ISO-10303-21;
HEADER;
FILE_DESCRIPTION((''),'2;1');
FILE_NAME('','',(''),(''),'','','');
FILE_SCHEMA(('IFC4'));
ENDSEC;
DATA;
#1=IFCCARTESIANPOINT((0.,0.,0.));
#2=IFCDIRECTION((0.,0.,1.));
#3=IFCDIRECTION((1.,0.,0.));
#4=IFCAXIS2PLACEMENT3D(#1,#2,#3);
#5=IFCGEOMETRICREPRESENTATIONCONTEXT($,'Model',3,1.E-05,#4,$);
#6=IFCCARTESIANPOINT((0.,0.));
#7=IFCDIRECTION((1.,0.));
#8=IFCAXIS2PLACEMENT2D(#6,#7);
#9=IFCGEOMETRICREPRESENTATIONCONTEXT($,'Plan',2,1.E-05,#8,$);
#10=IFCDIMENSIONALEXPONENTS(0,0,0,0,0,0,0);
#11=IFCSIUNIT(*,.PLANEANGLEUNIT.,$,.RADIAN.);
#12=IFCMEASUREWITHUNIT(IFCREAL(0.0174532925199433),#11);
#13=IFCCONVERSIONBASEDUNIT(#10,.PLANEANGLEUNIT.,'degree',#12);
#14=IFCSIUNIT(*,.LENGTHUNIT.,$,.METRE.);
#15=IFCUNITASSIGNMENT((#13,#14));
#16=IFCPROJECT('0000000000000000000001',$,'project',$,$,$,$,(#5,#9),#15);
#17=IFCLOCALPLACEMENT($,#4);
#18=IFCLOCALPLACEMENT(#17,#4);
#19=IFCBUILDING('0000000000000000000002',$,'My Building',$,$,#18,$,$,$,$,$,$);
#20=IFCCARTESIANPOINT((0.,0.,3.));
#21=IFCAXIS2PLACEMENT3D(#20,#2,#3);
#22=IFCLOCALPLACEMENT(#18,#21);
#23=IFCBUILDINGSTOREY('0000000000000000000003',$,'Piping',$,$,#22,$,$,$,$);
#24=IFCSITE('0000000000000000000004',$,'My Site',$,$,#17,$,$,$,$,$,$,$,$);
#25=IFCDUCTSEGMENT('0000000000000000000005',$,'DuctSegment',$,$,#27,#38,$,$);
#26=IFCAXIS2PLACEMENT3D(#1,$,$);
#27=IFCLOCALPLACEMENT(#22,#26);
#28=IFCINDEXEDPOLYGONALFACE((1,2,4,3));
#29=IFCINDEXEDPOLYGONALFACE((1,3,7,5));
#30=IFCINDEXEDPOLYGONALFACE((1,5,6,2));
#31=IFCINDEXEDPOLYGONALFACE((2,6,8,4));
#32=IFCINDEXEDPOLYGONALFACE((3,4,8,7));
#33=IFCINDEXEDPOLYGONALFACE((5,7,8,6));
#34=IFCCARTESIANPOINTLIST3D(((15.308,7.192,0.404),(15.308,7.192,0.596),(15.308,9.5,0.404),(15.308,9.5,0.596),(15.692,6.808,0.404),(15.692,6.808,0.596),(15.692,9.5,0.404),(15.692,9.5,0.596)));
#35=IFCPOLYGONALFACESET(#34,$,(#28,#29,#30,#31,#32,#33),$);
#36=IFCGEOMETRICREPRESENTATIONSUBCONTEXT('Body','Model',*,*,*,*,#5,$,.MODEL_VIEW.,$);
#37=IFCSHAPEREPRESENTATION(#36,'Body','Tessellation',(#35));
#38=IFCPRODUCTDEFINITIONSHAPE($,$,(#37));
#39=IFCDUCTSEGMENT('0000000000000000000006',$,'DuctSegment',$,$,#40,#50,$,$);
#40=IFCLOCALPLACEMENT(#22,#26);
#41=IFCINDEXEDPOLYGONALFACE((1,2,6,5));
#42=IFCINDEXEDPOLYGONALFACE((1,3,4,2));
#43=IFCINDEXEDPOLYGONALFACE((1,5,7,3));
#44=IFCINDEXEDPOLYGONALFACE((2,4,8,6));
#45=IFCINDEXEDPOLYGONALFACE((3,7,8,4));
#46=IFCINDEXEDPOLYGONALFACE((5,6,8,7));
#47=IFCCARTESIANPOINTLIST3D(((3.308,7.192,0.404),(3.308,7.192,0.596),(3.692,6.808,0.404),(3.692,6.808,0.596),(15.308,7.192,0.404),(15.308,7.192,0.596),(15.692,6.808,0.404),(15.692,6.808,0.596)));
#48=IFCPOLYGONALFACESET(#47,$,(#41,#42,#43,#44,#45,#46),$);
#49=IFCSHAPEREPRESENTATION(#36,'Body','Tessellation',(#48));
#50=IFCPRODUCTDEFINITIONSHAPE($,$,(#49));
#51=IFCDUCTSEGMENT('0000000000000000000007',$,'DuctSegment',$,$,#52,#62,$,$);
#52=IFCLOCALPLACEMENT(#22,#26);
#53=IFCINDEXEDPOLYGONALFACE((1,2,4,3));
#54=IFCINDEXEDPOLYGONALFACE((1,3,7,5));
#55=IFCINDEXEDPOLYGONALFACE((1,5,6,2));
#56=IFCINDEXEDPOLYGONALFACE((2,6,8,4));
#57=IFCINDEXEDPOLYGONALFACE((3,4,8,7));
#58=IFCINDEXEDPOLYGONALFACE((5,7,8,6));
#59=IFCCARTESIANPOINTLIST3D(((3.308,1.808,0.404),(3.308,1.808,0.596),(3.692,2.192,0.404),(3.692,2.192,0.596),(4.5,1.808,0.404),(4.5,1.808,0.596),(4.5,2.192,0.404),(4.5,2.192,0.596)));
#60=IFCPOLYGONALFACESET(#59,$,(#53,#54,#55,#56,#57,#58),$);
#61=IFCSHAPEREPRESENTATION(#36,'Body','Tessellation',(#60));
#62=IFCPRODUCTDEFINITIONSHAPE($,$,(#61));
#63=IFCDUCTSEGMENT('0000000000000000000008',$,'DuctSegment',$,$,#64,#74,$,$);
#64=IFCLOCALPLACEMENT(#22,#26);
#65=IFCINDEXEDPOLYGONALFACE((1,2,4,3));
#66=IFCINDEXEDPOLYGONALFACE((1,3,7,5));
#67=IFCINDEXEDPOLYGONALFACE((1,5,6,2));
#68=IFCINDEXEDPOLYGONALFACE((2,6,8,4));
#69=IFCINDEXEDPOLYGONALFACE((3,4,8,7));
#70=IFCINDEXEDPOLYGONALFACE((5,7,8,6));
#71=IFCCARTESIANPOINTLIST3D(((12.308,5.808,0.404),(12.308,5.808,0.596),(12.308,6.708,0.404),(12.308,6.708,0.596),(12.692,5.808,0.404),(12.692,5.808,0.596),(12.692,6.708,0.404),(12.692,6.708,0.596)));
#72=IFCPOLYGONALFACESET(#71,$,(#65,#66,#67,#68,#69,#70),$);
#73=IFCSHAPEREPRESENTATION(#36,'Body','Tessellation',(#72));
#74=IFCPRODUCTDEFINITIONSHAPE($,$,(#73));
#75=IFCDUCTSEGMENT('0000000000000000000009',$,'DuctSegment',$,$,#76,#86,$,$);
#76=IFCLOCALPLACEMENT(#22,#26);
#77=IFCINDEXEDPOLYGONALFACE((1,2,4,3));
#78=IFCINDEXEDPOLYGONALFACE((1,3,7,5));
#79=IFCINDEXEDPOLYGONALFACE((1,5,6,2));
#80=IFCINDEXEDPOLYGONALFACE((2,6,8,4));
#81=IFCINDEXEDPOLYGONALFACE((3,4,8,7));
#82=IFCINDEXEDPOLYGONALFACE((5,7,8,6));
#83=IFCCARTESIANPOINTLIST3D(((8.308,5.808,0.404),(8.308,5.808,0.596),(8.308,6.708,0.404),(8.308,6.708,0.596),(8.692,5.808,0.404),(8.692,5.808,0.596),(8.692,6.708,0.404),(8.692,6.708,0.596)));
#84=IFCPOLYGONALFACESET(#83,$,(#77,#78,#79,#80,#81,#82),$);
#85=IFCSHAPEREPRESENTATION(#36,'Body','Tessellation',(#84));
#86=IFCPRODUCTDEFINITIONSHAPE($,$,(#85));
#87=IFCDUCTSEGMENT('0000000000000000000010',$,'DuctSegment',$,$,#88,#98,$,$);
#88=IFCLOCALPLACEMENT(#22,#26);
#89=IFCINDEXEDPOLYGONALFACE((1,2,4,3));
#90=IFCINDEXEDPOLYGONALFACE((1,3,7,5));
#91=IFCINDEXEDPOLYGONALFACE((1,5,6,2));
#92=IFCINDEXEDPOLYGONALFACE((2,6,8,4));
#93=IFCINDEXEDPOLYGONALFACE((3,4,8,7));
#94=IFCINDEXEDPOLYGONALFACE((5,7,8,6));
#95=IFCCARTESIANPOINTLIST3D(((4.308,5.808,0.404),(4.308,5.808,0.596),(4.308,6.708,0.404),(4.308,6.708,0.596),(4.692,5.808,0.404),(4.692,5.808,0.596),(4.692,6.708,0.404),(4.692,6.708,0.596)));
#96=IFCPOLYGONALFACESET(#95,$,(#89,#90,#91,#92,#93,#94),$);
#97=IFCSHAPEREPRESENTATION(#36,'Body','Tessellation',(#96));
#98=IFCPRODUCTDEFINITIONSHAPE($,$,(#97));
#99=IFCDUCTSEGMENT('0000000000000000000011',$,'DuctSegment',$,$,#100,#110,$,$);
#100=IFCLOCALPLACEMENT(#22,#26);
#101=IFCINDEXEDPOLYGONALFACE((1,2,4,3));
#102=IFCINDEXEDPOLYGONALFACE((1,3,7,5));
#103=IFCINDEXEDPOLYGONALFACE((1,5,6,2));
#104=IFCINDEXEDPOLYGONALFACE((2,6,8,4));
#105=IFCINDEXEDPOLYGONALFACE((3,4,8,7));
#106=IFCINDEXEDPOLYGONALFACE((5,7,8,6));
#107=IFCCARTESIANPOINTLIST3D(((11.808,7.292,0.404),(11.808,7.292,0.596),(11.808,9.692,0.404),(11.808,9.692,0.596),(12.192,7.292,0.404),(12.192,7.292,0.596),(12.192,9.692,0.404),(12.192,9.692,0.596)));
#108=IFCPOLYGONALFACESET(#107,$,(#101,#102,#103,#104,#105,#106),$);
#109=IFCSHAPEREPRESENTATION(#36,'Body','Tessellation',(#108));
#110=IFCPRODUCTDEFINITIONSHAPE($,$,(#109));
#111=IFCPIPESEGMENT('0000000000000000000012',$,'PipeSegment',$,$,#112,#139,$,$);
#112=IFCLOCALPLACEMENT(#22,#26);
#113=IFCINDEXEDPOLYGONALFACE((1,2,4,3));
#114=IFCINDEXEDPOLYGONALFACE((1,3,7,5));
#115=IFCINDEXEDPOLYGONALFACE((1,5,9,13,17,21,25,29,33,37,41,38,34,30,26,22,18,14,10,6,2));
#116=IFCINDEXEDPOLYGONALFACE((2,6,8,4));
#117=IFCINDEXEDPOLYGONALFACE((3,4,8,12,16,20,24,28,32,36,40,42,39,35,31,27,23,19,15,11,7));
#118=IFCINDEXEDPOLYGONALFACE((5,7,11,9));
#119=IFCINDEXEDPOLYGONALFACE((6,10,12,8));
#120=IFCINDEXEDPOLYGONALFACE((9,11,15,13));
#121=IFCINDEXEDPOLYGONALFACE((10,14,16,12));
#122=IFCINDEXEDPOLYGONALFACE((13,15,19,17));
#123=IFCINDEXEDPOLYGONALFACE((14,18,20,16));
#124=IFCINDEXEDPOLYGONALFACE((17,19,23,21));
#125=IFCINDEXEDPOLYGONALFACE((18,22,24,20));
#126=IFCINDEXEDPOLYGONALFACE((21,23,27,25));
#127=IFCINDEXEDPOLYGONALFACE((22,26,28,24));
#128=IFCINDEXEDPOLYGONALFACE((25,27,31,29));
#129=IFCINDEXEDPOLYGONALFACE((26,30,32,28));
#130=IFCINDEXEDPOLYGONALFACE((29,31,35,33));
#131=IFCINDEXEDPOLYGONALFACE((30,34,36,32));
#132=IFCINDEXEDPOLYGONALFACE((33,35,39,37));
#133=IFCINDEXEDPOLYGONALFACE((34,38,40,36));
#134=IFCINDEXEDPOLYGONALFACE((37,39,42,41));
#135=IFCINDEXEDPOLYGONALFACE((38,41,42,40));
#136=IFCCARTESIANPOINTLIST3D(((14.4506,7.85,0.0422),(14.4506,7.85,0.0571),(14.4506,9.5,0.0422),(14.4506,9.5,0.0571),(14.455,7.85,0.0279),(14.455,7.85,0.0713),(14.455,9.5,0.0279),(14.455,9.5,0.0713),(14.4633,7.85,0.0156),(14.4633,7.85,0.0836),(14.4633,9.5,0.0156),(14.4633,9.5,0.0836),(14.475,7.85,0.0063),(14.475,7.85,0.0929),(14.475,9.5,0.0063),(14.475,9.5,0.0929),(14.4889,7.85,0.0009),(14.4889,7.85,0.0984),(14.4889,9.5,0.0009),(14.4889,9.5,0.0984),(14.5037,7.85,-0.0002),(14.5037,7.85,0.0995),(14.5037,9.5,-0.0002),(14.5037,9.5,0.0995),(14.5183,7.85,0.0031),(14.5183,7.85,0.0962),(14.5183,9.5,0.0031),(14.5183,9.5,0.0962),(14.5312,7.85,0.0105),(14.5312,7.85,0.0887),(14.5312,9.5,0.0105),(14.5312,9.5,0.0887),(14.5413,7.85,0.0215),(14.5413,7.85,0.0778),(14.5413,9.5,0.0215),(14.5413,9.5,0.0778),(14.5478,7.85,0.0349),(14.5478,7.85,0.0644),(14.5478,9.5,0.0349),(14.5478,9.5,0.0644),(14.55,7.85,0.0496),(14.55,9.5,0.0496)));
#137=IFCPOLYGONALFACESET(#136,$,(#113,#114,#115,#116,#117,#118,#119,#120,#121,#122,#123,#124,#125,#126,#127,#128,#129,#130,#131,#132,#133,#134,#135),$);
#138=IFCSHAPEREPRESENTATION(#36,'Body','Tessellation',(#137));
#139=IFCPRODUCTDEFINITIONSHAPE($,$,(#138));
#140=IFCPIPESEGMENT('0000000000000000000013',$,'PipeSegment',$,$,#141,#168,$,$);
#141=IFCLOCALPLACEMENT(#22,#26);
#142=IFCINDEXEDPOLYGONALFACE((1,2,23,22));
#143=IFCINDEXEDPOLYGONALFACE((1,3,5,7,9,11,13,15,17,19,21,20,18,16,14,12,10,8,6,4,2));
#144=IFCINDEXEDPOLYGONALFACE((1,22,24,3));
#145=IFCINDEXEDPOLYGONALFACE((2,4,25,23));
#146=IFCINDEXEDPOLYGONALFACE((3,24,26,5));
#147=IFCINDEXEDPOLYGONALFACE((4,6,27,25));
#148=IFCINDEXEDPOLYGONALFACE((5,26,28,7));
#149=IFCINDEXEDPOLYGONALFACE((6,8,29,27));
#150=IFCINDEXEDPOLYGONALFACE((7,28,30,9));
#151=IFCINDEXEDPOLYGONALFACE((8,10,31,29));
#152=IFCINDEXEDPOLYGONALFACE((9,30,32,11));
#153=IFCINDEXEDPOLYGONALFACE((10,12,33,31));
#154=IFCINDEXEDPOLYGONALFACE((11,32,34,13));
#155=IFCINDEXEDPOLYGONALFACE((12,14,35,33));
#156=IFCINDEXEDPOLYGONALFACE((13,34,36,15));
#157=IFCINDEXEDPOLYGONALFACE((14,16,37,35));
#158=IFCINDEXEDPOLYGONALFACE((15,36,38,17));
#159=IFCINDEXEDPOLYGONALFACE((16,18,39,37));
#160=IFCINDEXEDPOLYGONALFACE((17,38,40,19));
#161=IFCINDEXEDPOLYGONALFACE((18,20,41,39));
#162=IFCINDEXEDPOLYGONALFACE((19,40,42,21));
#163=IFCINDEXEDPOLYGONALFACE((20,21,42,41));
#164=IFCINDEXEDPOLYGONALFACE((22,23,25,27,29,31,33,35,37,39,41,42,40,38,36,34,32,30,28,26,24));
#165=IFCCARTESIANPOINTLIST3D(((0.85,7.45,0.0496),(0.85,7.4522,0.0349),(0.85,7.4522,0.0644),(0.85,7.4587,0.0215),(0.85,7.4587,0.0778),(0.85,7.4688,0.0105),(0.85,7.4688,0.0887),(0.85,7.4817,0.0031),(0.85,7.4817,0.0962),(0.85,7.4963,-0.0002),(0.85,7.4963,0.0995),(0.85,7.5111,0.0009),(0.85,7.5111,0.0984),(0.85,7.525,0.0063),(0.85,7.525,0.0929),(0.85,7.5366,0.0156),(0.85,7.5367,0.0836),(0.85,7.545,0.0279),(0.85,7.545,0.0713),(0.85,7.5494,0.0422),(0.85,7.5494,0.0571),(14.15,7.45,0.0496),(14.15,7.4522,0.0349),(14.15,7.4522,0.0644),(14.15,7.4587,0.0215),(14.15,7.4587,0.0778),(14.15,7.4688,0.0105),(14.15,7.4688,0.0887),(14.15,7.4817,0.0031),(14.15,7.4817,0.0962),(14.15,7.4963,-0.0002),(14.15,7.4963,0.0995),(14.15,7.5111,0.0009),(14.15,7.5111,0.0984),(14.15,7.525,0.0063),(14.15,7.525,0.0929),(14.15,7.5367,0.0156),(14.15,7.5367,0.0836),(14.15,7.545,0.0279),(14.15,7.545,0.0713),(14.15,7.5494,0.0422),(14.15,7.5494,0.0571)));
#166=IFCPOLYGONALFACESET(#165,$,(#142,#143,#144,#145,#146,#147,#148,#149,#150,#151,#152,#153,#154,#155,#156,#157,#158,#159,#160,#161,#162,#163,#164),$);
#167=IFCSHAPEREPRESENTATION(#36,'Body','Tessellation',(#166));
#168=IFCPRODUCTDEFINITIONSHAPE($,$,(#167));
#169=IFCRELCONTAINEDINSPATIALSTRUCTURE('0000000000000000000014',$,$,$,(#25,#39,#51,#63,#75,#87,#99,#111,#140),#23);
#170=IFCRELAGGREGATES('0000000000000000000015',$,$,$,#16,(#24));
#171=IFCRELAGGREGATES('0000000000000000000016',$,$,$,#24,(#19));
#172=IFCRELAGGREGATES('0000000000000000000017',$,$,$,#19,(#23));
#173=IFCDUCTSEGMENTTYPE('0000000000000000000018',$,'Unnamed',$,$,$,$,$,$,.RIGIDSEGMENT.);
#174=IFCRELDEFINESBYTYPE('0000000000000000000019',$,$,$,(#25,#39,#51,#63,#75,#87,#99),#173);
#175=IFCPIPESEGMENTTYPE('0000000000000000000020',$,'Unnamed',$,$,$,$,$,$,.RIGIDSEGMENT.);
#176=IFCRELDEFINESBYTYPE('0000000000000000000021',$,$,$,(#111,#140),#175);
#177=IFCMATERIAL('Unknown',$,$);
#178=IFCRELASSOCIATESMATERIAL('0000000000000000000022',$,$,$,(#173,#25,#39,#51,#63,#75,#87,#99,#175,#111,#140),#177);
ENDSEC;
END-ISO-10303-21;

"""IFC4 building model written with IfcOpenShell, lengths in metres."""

from ifc_helpers import new_model, entity, si_unit, converted_unit, frame, origin_with_axes, origin_2d_with_axis, place, context, subcontext, project, spatial, indexed_curve, circle, outline, extrude, clip, halfspace, material, material_profile, profile_set, profile_usage, type_object, element, save


model = new_model("IFC4")

# Units and contexts
model_context = context("Model", 3, precision=1e-05, world=origin_with_axes())
plan_context = context("Plan", 2, precision=1e-05, world=origin_2d_with_axis())
body_context = subcontext(model_context, "Body", "Model", "MODEL_VIEW")
ifc_project = project(units=[converted_unit("PLANEANGLEUNIT", "degree", entity("IfcReal", 0.0174532925199433), si_unit("PLANEANGLEUNIT", "RADIAN"), dimensions=[0, 0, 0, 0, 0, 0, 0]), si_unit("LENGTHUNIT", "METRE")], contexts=[model_context, plan_context])

# Site, building, storey
site_placement = place(None, origin_with_axes())
site = spatial("IfcSite", under=ifc_project, at=site_placement, Name="My Site")
building_placement = place(site_placement, origin_with_axes())
building = spatial("IfcBuilding", under=site, at=building_placement, Name="My Building")
storey_placement = place(building_placement, frame((0.0, 0.0, 3.0), z_axis=(0.0, 0.0, 1.0), x_axis=(1.0, 0.0, 0.0)))
storey = spatial("IfcBuildingStorey", under=building, at=storey_placement, Name="Piping")

# Duct segments
ifc_material = material(Name="Unknown")
ifc_material_profile_1 = material_profile(ifc_material, outline(indexed_curve([(-0.192, -0.096), (0.192, -0.096), (0.192, 0.096), (-0.192, 0.096), (-0.192, -0.096)])))
ifc_profile_set_1 = profile_set([ifc_material_profile_1])
ifc_profile_usage_1 = profile_usage(ifc_profile_set_1, cardinal=5)
duct_segment_type = type_object("IfcDuctSegmentType", Name="Unnamed", PredefinedType="RIGIDSEGMENT", material=ifc_profile_set_1)
duct_segment_1_placement = place(storey_placement, frame((15.5, 9.5, 0.5), z_axis=(0.0, -1.0, 0.0), x_axis=(1.0, 0.0, 0.0)))
element("IfcDuctSegment", 1, at=duct_segment_1_placement, inside=storey, type_object=duct_segment_type, material=ifc_profile_usage_1, Name="DuctSegment", context=body_context, shape_type="Clipping", body=[
    clip(extrude(outline(indexed_curve([(-0.192, -0.096), (0.192, -0.096), (0.192, 0.096), (-0.192, 0.096), (-0.192, -0.096)])), origin_with_axes(), (0.0, 0.0, 1.0), 2.692), halfspace(frame((0.192, -3.5, 2.692), z_axis=(-0.707106, 0.0, 0.707108), x_axis=(0.0, 1.0, 0.0)), False)),
])
ifc_profile_usage_2 = profile_usage(ifc_profile_set_1, cardinal=5)
duct_segment_2_placement = place(storey_placement, frame((15.692, 7.0, 0.5), z_axis=(-1.0, 0.0, 0.0), x_axis=(0.0, -1.0, 0.0)))
element("IfcDuctSegment", 2, at=duct_segment_2_placement, inside=storey, type_object=duct_segment_type, material=ifc_profile_usage_2, Name="DuctSegment", context=body_context, shape_type="Clipping", body=[
    clip(clip(extrude(outline(indexed_curve([(-0.192, -0.096), (0.192, -0.096), (0.192, 0.096), (-0.192, 0.096), (-0.192, -0.096)])), origin_with_axes(), (0.0, 0.0, 1.0), 12.384), halfspace(frame((-0.192, -3.5, 12.384), z_axis=(0.707107, 0.0, 0.707107), x_axis=(0.0, -1.0, 0.0)), False)), halfspace(frame((0.192, -3.5, 0.0), z_axis=(-0.707108, 0.0, -0.707106), x_axis=(0.0, 1.0, 0.0)), False)),
])
ifc_profile_usage_3 = profile_usage(ifc_profile_set_1, cardinal=5)
duct_segment_3_placement = place(storey_placement, frame((3.308, 2.0, 0.5), z_axis=(1.0, -0.000001, 0.0), x_axis=(0.000001, 1.0, 0.0)))
element("IfcDuctSegment", 3, at=duct_segment_3_placement, inside=storey, type_object=duct_segment_type, material=ifc_profile_usage_3, Name="DuctSegment", context=body_context, shape_type="Clipping", body=[
    clip(extrude(outline(indexed_curve([(-0.192, -0.096), (0.192, -0.096), (0.192, 0.096), (-0.192, 0.096), (-0.192, -0.096)])), origin_with_axes(), (0.0, 0.0, 1.0), 1.192), halfspace(frame((-0.192, -3.5, 0.0), z_axis=(0.707106, 0.0, -0.707107), x_axis=(0.0, -1.0, 0.0)), False)),
])
ifc_profile_usage_4 = profile_usage(ifc_profile_set_1, cardinal=5)
duct_segment_4_placement = place(storey_placement, frame((12.5, 6.708, 0.5), z_axis=(0.0, -1.0, 0.0), x_axis=(1.0, 0.0, 0.0)))
element("IfcDuctSegment", 4, at=duct_segment_4_placement, inside=storey, type_object=duct_segment_type, material=ifc_profile_usage_4, Name="DuctSegment", context=body_context, shape_type="SweptSolid", body=[
    extrude(outline(indexed_curve([(-0.192, -0.096), (0.192, -0.096), (0.192, 0.096), (-0.192, 0.096), (-0.192, -0.096)])), origin_with_axes(), (0.0, 0.0, 1.0), 0.9),
])
ifc_profile_usage_5 = profile_usage(ifc_profile_set_1, cardinal=5)
duct_segment_5_placement = place(storey_placement, frame((8.5, 6.708, 0.5), z_axis=(0.0, -1.0, 0.0), x_axis=(1.0, 0.0, 0.0)))
element("IfcDuctSegment", 5, at=duct_segment_5_placement, inside=storey, type_object=duct_segment_type, material=ifc_profile_usage_5, Name="DuctSegment", context=body_context, shape_type="SweptSolid", body=[
    extrude(outline(indexed_curve([(-0.192, -0.096), (0.192, -0.096), (0.192, 0.096), (-0.192, 0.096), (-0.192, -0.096)])), origin_with_axes(), (0.0, 0.0, 1.0), 0.9),
])
ifc_profile_usage_6 = profile_usage(ifc_profile_set_1, cardinal=5)
duct_segment_6_placement = place(storey_placement, frame((4.5, 6.708, 0.5), z_axis=(0.0, -1.0, 0.0), x_axis=(1.0, 0.0, 0.0)))
element("IfcDuctSegment", 6, at=duct_segment_6_placement, inside=storey, type_object=duct_segment_type, material=ifc_profile_usage_6, Name="DuctSegment", context=body_context, shape_type="SweptSolid", body=[
    extrude(outline(indexed_curve([(-0.192, -0.096), (0.192, -0.096), (0.192, 0.096), (-0.192, 0.096), (-0.192, -0.096)])), origin_with_axes(), (0.0, 0.0, 1.0), 0.9),
])
ifc_profile_usage_7 = profile_usage(ifc_profile_set_1, cardinal=5)
duct_segment_7_placement = place(storey_placement, frame((12.0, 7.292, 0.5), z_axis=(0.0, 1.0, 0.0), x_axis=(-1.0, 0.0, 0.0)))
element("IfcDuctSegment", 7, at=duct_segment_7_placement, inside=storey, type_object=duct_segment_type, material=ifc_profile_usage_7, Name="DuctSegment", context=body_context, shape_type="SweptSolid", body=[
    extrude(outline(indexed_curve([(-0.192, -0.096), (0.192, -0.096), (0.192, 0.096), (-0.192, 0.096), (-0.192, -0.096)])), origin_with_axes(), (0.0, 0.0, 1.0), 2.4),
])

# Pipe segments
ifc_material_profile_2 = material_profile(ifc_material, circle(Radius=0.05))
ifc_profile_set_2 = profile_set([ifc_material_profile_2])
ifc_profile_usage_8 = profile_usage(ifc_profile_set_2, cardinal=5)
pipe_segment_type = type_object("IfcPipeSegmentType", Name="Unnamed", PredefinedType="RIGIDSEGMENT", material=ifc_profile_set_2)
pipe_segment_1_placement = place(storey_placement, frame((14.5, 9.5, 0.0496), z_axis=(0.0, -1.0, 0.0), x_axis=(1.0, 0.0, 0.0)))
element("IfcPipeSegment", 8, at=pipe_segment_1_placement, inside=storey, type_object=pipe_segment_type, material=ifc_profile_usage_8, Name="PipeSegment", context=body_context, shape_type="SweptSolid", body=[
    extrude(circle(Radius=0.05), origin_with_axes(), (0.0, 0.0, 1.0), 1.65),
])
ifc_profile_usage_9 = profile_usage(ifc_profile_set_2, cardinal=5)
pipe_segment_2_placement = place(storey_placement, frame((14.15, 7.5, 0.0496), z_axis=(-1.0, 0.0, 0.0), x_axis=(0.0, -1.0, 0.0)))
element("IfcPipeSegment", 9, at=pipe_segment_2_placement, inside=storey, type_object=pipe_segment_type, material=ifc_profile_usage_9, Name="PipeSegment", context=body_context, shape_type="SweptSolid", body=[
    extrude(circle(Radius=0.05), origin_with_axes(), (0.0, 0.0, 1.0), 13.3),
])

save(model, "model.ifc")
